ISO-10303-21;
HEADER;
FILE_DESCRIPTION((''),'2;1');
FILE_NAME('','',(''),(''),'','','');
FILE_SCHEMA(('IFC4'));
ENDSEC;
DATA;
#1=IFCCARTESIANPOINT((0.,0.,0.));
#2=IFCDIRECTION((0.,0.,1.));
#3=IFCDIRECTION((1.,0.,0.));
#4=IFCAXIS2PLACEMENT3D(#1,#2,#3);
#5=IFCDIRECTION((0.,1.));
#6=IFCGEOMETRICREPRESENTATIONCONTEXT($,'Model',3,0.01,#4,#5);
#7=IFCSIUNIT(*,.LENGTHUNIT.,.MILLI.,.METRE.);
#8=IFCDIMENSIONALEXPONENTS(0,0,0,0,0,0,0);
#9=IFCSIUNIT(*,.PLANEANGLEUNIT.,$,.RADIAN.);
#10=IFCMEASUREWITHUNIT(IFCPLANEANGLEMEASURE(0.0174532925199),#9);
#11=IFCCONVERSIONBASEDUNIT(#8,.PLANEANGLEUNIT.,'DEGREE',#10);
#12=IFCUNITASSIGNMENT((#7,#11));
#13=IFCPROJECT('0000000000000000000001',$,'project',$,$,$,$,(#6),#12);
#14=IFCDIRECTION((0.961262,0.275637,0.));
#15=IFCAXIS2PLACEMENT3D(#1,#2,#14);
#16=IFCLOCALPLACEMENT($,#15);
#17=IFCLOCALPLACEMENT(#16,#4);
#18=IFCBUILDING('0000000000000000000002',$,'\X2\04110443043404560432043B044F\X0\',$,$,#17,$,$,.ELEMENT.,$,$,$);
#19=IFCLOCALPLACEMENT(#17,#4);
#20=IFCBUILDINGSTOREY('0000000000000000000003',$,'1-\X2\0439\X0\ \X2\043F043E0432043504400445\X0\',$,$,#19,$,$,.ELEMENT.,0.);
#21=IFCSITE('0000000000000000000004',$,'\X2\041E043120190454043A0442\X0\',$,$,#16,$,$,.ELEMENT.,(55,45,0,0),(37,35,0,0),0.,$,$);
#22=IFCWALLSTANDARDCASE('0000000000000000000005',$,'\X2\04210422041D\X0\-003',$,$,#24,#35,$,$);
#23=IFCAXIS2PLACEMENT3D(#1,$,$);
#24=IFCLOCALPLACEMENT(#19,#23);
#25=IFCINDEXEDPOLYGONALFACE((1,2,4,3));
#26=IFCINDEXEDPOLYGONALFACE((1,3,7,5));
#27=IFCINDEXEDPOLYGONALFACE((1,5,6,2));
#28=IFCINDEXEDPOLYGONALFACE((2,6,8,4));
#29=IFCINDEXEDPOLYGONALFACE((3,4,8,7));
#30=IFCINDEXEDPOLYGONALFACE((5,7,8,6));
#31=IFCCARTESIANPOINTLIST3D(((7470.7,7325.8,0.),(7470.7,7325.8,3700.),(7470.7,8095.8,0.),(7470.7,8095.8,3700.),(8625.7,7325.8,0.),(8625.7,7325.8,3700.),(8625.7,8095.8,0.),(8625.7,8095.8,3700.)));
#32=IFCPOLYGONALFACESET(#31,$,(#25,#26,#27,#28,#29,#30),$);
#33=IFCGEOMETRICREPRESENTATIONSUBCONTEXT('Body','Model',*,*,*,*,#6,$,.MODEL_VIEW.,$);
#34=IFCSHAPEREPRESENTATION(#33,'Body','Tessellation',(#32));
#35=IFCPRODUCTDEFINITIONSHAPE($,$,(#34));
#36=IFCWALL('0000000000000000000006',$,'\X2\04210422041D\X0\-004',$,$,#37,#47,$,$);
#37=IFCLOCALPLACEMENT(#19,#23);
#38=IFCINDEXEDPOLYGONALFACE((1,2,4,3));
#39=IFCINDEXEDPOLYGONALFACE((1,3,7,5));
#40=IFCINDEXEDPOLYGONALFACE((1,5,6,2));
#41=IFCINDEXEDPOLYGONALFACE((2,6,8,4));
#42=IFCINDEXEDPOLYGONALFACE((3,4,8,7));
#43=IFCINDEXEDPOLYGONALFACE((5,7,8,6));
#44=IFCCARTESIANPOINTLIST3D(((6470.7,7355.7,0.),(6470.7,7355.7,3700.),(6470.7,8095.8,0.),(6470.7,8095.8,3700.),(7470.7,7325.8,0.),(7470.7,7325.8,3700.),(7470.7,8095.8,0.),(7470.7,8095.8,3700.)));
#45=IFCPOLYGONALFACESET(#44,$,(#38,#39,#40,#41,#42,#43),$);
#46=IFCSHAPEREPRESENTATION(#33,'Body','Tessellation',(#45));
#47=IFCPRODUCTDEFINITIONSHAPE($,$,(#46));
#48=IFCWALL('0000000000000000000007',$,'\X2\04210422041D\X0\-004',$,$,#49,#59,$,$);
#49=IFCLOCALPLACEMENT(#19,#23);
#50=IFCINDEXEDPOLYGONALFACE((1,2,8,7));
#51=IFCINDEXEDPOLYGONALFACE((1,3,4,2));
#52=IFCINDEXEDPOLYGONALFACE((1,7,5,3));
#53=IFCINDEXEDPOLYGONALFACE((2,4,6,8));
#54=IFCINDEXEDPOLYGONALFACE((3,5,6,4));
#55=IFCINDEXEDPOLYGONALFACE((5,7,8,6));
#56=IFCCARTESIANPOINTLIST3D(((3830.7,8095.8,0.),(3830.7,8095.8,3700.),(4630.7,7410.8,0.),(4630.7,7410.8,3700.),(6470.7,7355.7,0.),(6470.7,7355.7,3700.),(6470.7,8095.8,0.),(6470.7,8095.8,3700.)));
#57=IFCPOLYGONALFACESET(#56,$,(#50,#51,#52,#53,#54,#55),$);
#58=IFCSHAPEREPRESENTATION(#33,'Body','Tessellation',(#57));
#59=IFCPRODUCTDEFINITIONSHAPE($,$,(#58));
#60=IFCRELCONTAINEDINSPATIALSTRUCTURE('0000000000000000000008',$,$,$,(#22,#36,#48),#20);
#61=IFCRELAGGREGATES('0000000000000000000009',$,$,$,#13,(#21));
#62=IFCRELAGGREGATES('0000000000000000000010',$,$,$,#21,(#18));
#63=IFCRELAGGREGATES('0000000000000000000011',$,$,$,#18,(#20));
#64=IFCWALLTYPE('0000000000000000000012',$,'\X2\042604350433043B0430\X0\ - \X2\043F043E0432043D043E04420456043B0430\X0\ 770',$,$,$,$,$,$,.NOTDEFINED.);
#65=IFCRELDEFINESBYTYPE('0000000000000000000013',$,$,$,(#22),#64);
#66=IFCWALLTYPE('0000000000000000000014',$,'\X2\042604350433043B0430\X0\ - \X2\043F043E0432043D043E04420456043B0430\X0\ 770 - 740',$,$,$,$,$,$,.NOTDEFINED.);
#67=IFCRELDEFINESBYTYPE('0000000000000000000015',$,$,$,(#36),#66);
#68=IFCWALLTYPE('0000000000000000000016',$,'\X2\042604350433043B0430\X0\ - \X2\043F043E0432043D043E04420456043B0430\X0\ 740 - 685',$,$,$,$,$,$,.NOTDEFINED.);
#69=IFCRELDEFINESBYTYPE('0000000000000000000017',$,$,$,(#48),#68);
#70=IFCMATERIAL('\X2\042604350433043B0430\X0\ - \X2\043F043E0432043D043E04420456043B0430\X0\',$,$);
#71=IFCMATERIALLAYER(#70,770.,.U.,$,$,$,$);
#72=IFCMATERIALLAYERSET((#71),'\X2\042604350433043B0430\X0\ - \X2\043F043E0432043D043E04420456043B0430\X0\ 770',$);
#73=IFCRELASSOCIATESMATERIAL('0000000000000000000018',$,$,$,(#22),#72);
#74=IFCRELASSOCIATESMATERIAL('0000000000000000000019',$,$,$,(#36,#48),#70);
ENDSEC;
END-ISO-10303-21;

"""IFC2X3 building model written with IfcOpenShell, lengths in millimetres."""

from ifc_helpers import new_model, entity, si_unit, converted_unit, direction, frame, origin_with_axes, place, context, subcontext, project, spatial, polyline, outline, extrude, material, layer, layer_set, layer_usage, type_object, element, save


model = new_model("IFC2X3")

# Units and contexts
model_context = context("Model", 3, precision=0.01, world=origin_with_axes(), true_north=direction((0.0, 1.0)))
body_context = subcontext(model_context, "Body", "Model", "MODEL_VIEW")
ifc_project = project(units=[si_unit("LENGTHUNIT", "METRE", prefix="MILLI"), converted_unit("PLANEANGLEUNIT", "DEGREE", entity("IfcPlaneAngleMeasure", 0.0174532925199), si_unit("PLANEANGLEUNIT", "RADIAN"), dimensions=[0, 0, 0, 0, 0, 0, 0])], contexts=[model_context])

# Site, building, storey
site_placement = place(None, frame((0.0, 0.0, 0.0), z_axis=(0.0, 0.0, 1.0), x_axis=(0.961262, 0.275637, 0.0)))
site = spatial("IfcSite", under=ifc_project, at=site_placement, Name="Об’єкт", CompositionType="ELEMENT", RefLatitude=(55, 45, 0, 0), RefLongitude=(37, 35, 0, 0), RefElevation=0.0)
building_placement = place(site_placement, origin_with_axes())
building = spatial("IfcBuilding", under=site, at=building_placement, Name="Будівля", CompositionType="ELEMENT")
storey_placement = place(building_placement, origin_with_axes())
storey = spatial("IfcBuildingStorey", under=building, at=storey_placement, Name="1-й поверх", CompositionType="ELEMENT", Elevation=0.0)

# Walls
ifc_material_1 = material(Name="Цегла - повнотіла")
ifc_layer_1 = layer(ifc_material_1, 770.0, ventilated="UNKNOWN")
ifc_layer_set_1 = layer_set([ifc_layer_1], Name="Цегла - повнотіла 770")
ifc_layer_usage_1 = layer_usage(ifc_layer_set_1, "AXIS2", "POSITIVE", 0.0)
wall_type_1 = type_object("IfcWallType", Name="Цегла - повнотіла 770", PredefinedType="NOTDEFINED")
wall_1_placement = place(storey_placement, frame((8625.7, 8095.8, 0.0), z_axis=(0.0, 0.0, 1.0), x_axis=(-1.0, 0.0, 0.0)))
element("IfcWallStandardCase", 1, at=wall_1_placement, inside=storey, type_object=wall_type_1, material=ifc_layer_usage_1, Name="СТН-003", context=body_context, shape_type="SweptSolid", body=[
    extrude(outline(polyline([(0.0, 0.0), (1155.0, 0.0), (1155.0, 770.0), (0.0, 770.0), (0.0, 0.0)])), origin_with_axes(), (0.0, 0.0, 1.0), 3700.0),
])
wall_type_2 = type_object("IfcWallType", Name="Цегла - повнотіла 770 - 740", PredefinedType="NOTDEFINED")
wall_2_placement = place(storey_placement, frame((7470.7, 8095.8, 0.0), z_axis=(0.0, 0.0, 1.0), x_axis=(-1.0, 0.0, 0.0)))
element("IfcWall", 2, at=wall_2_placement, inside=storey, type_object=wall_type_2, material=ifc_material_1, Name="СТН-004", context=body_context, shape_type="SweptSolid", body=[
    extrude(outline(polyline([(0.0, 0.0), (1000.0, 0.0), (1000.0, 740.1), (0.0, 770.0), (0.0, 0.0)])), origin_with_axes(), (0.0, 0.0, 1.0), 3700.0),
])
wall_type_3 = type_object("IfcWallType", Name="Цегла - повнотіла 740 - 685", PredefinedType="NOTDEFINED")
wall_3_placement = place(storey_placement, frame((6470.7, 8095.8, 0.0), z_axis=(0.0, 0.0, 1.0), x_axis=(-1.0, 0.0, 0.0)))
element("IfcWall", 3, at=wall_3_placement, inside=storey, type_object=wall_type_3, material=ifc_material_1, Name="СТН-004", context=body_context, shape_type="SweptSolid", body=[
    extrude(outline(polyline([(0.0, 0.0), (2640.0, 0.0), (1840.0, 685.0), (0.0, 740.1), (0.0, 0.0)])), origin_with_axes(), (0.0, 0.0, 1.0), 3700.0),
])

save(model, "model.ifc")
